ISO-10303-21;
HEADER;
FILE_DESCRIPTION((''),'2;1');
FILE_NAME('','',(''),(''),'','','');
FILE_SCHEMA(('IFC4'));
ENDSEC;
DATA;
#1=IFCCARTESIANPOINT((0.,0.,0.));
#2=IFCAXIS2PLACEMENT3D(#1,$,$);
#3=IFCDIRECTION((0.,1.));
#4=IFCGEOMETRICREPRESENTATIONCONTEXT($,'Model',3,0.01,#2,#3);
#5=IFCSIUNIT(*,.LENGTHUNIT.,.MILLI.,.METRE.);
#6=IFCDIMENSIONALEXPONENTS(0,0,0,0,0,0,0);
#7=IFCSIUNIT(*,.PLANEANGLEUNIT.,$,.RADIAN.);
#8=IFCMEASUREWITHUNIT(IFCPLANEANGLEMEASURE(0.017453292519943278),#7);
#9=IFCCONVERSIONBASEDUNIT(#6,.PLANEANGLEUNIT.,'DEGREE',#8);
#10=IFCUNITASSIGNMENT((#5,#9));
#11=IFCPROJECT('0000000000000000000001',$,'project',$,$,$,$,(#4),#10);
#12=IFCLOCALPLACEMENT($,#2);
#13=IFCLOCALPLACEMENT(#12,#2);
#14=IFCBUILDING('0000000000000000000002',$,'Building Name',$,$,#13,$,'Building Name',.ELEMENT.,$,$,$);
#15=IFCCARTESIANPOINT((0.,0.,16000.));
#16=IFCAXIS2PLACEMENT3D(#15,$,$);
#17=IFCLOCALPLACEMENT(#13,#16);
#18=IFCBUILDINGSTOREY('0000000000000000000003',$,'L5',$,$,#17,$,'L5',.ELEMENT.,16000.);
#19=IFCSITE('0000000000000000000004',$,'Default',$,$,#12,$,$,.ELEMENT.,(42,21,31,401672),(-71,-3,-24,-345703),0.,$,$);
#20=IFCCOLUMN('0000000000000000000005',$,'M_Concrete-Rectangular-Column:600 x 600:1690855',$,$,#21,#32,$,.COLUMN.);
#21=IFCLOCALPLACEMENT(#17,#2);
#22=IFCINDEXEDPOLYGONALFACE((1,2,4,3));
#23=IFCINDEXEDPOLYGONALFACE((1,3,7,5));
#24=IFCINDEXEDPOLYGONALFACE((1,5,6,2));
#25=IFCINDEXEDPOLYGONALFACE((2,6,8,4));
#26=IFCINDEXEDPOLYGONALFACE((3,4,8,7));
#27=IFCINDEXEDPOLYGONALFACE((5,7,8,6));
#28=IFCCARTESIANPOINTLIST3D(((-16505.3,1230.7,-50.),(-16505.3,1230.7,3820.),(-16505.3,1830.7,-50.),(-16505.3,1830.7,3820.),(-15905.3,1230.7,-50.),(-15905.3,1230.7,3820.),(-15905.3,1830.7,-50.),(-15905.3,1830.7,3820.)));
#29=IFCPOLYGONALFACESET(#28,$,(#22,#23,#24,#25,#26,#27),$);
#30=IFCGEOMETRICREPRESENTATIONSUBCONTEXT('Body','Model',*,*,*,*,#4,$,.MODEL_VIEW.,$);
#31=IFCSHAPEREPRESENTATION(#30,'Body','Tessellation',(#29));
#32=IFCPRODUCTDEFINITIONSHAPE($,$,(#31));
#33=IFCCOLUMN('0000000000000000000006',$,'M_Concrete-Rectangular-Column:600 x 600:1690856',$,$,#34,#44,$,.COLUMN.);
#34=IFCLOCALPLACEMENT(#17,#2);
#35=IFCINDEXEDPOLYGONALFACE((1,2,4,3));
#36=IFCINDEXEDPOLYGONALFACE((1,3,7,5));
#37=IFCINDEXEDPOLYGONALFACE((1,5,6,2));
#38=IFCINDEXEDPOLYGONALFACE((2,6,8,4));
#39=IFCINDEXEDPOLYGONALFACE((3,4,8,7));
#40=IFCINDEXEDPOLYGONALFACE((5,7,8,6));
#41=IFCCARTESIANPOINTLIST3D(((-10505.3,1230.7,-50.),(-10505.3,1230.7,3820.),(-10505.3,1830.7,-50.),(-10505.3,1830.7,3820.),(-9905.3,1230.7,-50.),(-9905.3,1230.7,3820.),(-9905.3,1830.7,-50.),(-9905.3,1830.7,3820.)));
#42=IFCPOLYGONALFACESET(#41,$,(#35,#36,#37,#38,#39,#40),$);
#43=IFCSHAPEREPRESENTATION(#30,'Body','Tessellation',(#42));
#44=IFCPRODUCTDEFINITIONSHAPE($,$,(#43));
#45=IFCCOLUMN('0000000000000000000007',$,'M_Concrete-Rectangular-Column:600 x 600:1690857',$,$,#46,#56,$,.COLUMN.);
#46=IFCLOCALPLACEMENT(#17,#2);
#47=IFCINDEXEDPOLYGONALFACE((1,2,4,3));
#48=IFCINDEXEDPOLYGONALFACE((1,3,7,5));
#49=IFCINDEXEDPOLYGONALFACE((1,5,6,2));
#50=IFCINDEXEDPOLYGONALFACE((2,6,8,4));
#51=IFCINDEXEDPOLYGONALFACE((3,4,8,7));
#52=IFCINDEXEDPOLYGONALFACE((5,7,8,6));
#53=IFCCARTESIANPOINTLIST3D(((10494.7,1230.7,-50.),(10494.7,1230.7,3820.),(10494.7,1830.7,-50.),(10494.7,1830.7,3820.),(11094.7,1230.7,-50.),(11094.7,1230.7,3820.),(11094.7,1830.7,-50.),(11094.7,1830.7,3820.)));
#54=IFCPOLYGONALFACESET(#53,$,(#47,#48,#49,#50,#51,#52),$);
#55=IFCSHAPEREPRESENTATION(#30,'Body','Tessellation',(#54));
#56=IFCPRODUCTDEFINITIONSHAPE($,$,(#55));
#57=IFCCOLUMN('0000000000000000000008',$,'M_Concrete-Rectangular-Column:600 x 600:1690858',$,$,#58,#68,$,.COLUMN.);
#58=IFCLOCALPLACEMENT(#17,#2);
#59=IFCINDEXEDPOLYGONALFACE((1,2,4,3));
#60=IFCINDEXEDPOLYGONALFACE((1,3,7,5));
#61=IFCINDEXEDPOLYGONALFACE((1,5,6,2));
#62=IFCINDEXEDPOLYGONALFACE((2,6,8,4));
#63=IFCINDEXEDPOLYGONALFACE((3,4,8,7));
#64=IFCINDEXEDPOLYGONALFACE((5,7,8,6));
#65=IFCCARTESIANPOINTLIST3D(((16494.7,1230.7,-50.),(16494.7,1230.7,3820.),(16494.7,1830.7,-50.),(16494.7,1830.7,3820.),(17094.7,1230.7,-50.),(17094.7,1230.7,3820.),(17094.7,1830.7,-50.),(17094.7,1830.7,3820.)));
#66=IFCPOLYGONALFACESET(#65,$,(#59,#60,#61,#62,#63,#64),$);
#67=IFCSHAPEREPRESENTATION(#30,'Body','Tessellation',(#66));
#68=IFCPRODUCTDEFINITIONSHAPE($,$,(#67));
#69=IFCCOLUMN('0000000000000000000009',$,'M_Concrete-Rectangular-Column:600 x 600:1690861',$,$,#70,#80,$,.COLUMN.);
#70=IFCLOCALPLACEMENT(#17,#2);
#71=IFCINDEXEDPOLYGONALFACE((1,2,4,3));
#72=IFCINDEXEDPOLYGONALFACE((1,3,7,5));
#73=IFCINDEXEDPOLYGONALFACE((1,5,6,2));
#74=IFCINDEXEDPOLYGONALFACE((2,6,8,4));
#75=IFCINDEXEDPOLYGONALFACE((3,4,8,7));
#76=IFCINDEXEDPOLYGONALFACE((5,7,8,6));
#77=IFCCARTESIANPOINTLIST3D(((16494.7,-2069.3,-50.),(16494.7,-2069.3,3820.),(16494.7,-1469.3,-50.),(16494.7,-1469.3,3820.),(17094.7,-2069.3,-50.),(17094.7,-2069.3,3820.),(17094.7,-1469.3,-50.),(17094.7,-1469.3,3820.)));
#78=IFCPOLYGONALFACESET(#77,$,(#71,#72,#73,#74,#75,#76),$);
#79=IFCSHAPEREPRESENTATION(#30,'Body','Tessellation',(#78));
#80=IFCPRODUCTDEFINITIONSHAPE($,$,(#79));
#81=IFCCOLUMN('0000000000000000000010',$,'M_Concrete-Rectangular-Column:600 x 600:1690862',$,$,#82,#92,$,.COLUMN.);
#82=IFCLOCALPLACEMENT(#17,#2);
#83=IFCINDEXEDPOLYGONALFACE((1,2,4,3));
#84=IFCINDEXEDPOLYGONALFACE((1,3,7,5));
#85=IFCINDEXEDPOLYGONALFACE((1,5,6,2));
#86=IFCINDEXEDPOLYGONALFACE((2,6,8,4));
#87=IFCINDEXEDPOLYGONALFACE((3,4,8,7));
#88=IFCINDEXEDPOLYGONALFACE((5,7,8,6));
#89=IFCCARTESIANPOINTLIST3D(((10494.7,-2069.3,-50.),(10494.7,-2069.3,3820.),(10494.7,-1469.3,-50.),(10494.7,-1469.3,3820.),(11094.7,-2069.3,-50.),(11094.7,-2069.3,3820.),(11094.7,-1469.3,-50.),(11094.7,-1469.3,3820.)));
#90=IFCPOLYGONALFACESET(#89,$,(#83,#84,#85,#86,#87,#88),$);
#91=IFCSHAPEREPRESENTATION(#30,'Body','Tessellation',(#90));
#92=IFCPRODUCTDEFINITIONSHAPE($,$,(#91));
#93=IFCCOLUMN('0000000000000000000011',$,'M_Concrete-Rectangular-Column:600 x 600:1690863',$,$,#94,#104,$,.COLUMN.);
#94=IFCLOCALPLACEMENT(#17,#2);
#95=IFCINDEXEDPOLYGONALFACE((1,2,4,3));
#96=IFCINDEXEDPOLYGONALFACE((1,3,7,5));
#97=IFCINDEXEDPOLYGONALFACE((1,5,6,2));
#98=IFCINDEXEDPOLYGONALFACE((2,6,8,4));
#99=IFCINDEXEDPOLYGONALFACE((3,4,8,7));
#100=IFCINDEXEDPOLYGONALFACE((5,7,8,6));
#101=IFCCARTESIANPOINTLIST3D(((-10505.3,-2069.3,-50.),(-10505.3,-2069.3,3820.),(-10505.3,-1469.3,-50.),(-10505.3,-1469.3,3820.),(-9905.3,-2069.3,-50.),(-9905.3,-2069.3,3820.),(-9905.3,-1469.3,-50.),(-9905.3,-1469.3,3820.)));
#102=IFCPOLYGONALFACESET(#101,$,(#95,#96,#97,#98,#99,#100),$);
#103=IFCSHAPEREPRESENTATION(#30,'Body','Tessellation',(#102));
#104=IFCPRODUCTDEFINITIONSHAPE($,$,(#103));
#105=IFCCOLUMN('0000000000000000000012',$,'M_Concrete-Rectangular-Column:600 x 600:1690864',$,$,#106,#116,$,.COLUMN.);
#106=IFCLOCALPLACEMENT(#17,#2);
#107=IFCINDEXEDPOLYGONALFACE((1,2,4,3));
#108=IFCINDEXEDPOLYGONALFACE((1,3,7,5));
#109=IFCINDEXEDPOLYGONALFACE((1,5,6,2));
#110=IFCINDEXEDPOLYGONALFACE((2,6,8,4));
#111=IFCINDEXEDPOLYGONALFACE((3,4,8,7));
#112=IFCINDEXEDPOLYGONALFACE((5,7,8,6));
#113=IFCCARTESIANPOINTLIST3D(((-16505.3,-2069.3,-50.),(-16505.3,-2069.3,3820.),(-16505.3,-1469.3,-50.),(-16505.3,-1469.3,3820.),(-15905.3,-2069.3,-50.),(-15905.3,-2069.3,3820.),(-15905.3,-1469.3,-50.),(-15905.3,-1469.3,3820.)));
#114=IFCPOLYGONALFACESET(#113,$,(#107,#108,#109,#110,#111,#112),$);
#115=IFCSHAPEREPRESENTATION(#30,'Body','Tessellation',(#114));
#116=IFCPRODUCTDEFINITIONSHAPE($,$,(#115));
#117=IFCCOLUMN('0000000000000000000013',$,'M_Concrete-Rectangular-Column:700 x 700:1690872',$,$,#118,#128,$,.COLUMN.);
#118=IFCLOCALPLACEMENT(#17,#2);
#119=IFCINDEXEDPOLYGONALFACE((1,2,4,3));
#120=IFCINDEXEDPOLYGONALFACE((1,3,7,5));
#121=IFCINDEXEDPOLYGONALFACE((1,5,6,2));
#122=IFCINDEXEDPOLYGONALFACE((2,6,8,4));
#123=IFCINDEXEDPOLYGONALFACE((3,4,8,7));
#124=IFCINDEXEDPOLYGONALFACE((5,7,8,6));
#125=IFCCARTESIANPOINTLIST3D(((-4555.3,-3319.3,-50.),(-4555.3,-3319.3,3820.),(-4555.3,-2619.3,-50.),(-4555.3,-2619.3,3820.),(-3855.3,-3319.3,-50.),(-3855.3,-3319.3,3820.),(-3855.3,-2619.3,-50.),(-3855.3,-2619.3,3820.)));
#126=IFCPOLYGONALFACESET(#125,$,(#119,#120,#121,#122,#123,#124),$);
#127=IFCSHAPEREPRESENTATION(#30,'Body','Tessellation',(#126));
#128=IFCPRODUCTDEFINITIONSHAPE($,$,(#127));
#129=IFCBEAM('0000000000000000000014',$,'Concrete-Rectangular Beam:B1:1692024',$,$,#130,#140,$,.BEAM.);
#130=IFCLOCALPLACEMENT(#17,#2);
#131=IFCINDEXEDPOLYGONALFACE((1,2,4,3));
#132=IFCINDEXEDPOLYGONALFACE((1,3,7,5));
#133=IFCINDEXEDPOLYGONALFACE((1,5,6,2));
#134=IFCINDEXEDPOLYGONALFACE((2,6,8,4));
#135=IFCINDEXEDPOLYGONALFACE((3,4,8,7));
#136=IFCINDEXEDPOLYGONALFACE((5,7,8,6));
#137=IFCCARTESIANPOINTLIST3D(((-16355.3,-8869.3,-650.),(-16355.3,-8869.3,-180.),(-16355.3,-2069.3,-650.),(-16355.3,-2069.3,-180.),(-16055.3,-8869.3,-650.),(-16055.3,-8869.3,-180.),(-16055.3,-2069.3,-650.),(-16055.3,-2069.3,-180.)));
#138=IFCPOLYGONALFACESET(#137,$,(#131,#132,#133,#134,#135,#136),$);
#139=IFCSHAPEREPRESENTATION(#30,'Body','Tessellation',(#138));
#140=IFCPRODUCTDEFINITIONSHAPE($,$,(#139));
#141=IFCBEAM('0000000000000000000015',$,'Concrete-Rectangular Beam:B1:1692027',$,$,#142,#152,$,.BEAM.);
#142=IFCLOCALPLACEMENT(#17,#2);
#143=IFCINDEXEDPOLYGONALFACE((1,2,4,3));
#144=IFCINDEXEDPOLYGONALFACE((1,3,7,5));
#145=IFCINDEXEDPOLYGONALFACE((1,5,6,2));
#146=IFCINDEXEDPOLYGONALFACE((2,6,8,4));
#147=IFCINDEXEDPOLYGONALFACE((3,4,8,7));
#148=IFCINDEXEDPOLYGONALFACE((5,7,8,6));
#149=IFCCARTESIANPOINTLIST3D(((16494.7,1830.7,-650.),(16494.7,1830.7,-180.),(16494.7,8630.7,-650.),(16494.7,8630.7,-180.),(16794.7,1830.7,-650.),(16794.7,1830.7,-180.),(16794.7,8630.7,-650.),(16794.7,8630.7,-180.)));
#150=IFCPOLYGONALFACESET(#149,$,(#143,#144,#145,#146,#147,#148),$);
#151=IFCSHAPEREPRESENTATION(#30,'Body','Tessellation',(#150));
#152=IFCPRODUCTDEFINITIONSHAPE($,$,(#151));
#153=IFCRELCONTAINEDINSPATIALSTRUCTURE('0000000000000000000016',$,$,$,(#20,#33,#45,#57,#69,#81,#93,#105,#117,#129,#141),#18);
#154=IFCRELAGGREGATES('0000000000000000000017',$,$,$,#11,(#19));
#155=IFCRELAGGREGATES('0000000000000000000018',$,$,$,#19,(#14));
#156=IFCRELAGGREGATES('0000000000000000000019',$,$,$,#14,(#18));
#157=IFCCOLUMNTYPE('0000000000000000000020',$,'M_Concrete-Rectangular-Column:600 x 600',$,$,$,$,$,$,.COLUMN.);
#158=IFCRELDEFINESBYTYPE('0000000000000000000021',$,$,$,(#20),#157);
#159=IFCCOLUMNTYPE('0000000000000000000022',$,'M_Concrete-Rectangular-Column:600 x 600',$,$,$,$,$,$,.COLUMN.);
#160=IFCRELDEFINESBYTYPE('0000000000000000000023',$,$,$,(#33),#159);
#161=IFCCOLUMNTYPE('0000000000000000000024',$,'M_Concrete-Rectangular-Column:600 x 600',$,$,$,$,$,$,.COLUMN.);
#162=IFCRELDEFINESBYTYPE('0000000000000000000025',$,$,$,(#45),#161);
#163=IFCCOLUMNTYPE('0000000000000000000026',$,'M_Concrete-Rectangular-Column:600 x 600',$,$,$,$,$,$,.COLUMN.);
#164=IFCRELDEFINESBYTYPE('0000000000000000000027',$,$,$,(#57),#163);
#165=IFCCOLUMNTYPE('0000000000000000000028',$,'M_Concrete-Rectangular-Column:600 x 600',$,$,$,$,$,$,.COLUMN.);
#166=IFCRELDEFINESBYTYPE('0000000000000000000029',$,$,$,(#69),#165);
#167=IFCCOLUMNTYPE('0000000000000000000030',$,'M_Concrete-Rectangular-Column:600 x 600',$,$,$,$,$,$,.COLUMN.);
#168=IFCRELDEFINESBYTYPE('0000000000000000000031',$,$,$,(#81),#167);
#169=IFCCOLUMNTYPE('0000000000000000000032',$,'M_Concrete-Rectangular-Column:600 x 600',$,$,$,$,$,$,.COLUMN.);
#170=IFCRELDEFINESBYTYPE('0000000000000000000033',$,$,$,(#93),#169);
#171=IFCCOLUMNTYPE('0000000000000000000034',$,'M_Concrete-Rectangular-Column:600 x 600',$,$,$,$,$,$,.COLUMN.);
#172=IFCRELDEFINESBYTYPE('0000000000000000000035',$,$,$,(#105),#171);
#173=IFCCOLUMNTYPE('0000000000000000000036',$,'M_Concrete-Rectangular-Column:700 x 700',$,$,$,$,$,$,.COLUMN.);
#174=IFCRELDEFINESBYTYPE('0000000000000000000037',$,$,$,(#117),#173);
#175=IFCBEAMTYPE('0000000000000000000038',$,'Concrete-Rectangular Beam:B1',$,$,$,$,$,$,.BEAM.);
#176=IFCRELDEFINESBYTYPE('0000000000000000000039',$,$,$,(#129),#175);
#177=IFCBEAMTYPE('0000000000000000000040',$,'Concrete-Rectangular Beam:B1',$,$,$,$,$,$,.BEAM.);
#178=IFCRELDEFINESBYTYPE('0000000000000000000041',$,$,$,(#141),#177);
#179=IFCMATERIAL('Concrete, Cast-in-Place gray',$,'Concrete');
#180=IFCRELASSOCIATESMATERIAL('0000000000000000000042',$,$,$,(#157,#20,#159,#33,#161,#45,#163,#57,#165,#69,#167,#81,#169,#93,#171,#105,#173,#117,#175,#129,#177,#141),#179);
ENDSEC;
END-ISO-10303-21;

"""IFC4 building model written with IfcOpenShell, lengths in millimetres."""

from ifc_helpers import new_model, entity, si_unit, converted_unit, direction, frame, origin, place, context, subcontext, project, spatial, indexed_curve, outline, extrude, source, transform, mapped, material, type_object, type_shapes, element, save


model = new_model("IFC4")

# Units and contexts
model_context = context("Model", 3, precision=0.01, world=origin(), true_north=direction((0.0, 1.0)))
body_context = subcontext(model_context, "Body", "Model", "MODEL_VIEW")
ifc_project = project(units=[si_unit("LENGTHUNIT", "METRE", prefix="MILLI"), converted_unit("PLANEANGLEUNIT", "DEGREE", entity("IfcPlaneAngleMeasure", 0.017453292519943278), si_unit("PLANEANGLEUNIT", "RADIAN"), dimensions=[0, 0, 0, 0, 0, 0, 0])], contexts=[model_context])

# Site, building, storey
site_placement = place(None, origin())
site = spatial("IfcSite", under=ifc_project, at=site_placement, Name="Default", CompositionType="ELEMENT", RefLatitude=(42, 21, 31, 401672), RefLongitude=(-71, -3, -24, -345703), RefElevation=0.0)
building_placement = place(site_placement, origin())
building = spatial("IfcBuilding", under=site, at=building_placement, Name="Building Name", LongName="Building Name", CompositionType="ELEMENT")
storey_placement = place(building_placement, frame((0.0, 0.0, 16000.0)))
storey = spatial("IfcBuildingStorey", under=building, at=storey_placement, Name="L5", LongName="L5", CompositionType="ELEMENT", Elevation=16000.0)

# Columns
ifc_material = material(Name="Concrete, Cast-in-Place gray", Category="Concrete")
column_type_1 = type_object("IfcColumnType", Name="M_Concrete-Rectangular-Column:600 x 600", PredefinedType="COLUMN", material=ifc_material)
shared_shape_1 = source(origin(), body_context, "Body", "SweptSolid", [
    extrude(outline(indexed_curve([(-300.0, -300.0), (300.0, -300.0), (300.0, 300.0), (-300.0, 300.0), (-300.0, -300.0)], self_intersect=False)), frame((-16205.3, 1530.7, 15950.0), z_axis=(0.0, 0.0, 1.0), x_axis=(-1.0, 0.0, 0.0)), (0.0, 0.0, 1.0), 3870.0),
])
type_shapes(column_type_1, [shared_shape_1])
column_1_placement = place(storey_placement, frame((0.0, 0.0, -16000.0)))
element("IfcColumn", 1, at=column_1_placement, inside=storey, type_object=column_type_1, material=ifc_material, Name="M_Concrete-Rectangular-Column:600 x 600:1690855", PredefinedType="COLUMN", context=body_context, shape_type="MappedRepresentation", body=[
    mapped(shared_shape_1, transform((0.0, 0.0, 0.0), scale=1.0)),
])
column_type_2 = type_object("IfcColumnType", Name="M_Concrete-Rectangular-Column:600 x 600", PredefinedType="COLUMN", material=ifc_material)
shared_shape_2 = source(origin(), body_context, "Body", "SweptSolid", [
    extrude(outline(indexed_curve([(-300.0, -300.0), (300.0, -300.0), (300.0, 300.0), (-300.0, 300.0), (-300.0, -300.0)], self_intersect=False)), frame((-10205.3, 1530.7, 15950.0), z_axis=(0.0, 0.0, 1.0), x_axis=(-1.0, 0.0, 0.0)), (0.0, 0.0, 1.0), 3870.0),
])
type_shapes(column_type_2, [shared_shape_2])
column_2_placement = place(storey_placement, frame((0.0, 0.0, -16000.0)))
element("IfcColumn", 2, at=column_2_placement, inside=storey, type_object=column_type_2, material=ifc_material, Name="M_Concrete-Rectangular-Column:600 x 600:1690856", PredefinedType="COLUMN", context=body_context, shape_type="MappedRepresentation", body=[
    mapped(shared_shape_2, transform((0.0, 0.0, 0.0), scale=1.0)),
])
column_type_3 = type_object("IfcColumnType", Name="M_Concrete-Rectangular-Column:600 x 600", PredefinedType="COLUMN", material=ifc_material)
shared_shape_3 = source(origin(), body_context, "Body", "SweptSolid", [
    extrude(outline(indexed_curve([(-300.0, -300.0), (300.0, -300.0), (300.0, 300.0), (-300.0, 300.0), (-300.0, -300.0)], self_intersect=False)), frame((10794.7, 1530.7, 15950.0), z_axis=(0.0, 0.0, 1.0), x_axis=(-1.0, 0.0, 0.0)), (0.0, 0.0, 1.0), 3870.0),
])
type_shapes(column_type_3, [shared_shape_3])
column_3_placement = place(storey_placement, frame((0.0, 0.0, -16000.0)))
element("IfcColumn", 3, at=column_3_placement, inside=storey, type_object=column_type_3, material=ifc_material, Name="M_Concrete-Rectangular-Column:600 x 600:1690857", PredefinedType="COLUMN", context=body_context, shape_type="MappedRepresentation", body=[
    mapped(shared_shape_3, transform((0.0, 0.0, 0.0), scale=1.0)),
])
column_type_4 = type_object("IfcColumnType", Name="M_Concrete-Rectangular-Column:600 x 600", PredefinedType="COLUMN", material=ifc_material)
shared_shape_4 = source(origin(), body_context, "Body", "SweptSolid", [
    extrude(outline(indexed_curve([(-300.0, -300.0), (300.0, -300.0), (300.0, 300.0), (-300.0, 300.0), (-300.0, -300.0)], self_intersect=False)), frame((16794.7, 1530.7, 15950.0), z_axis=(0.0, 0.0, 1.0), x_axis=(-1.0, 0.0, 0.0)), (0.0, 0.0, 1.0), 3870.0),
])
type_shapes(column_type_4, [shared_shape_4])
column_4_placement = place(storey_placement, frame((0.0, 0.0, -16000.0)))
element("IfcColumn", 4, at=column_4_placement, inside=storey, type_object=column_type_4, material=ifc_material, Name="M_Concrete-Rectangular-Column:600 x 600:1690858", PredefinedType="COLUMN", context=body_context, shape_type="MappedRepresentation", body=[
    mapped(shared_shape_4, transform((0.0, 0.0, 0.0), scale=1.0)),
])
column_type_5 = type_object("IfcColumnType", Name="M_Concrete-Rectangular-Column:600 x 600", PredefinedType="COLUMN", material=ifc_material)
shared_shape_5 = source(origin(), body_context, "Body", "SweptSolid", [
    extrude(outline(indexed_curve([(-300.0, -300.0), (300.0, -300.0), (300.0, 300.0), (-300.0, 300.0), (-300.0, -300.0)], self_intersect=False)), frame((16794.7, -1769.3, 15950.0), z_axis=(0.0, 0.0, 1.0), x_axis=(-1.0, 0.0, 0.0)), (0.0, 0.0, 1.0), 3870.0),
])
type_shapes(column_type_5, [shared_shape_5])
column_5_placement = place(storey_placement, frame((0.0, 0.0, -16000.0)))
element("IfcColumn", 5, at=column_5_placement, inside=storey, type_object=column_type_5, material=ifc_material, Name="M_Concrete-Rectangular-Column:600 x 600:1690861", PredefinedType="COLUMN", context=body_context, shape_type="MappedRepresentation", body=[
    mapped(shared_shape_5, transform((0.0, 0.0, 0.0), scale=1.0)),
])
column_type_6 = type_object("IfcColumnType", Name="M_Concrete-Rectangular-Column:600 x 600", PredefinedType="COLUMN", material=ifc_material)
shared_shape_6 = source(origin(), body_context, "Body", "SweptSolid", [
    extrude(outline(indexed_curve([(-300.0, -300.0), (300.0, -300.0), (300.0, 300.0), (-300.0, 300.0), (-300.0, -300.0)], self_intersect=False)), frame((10794.7, -1769.3, 15950.0), z_axis=(0.0, 0.0, 1.0), x_axis=(-1.0, 0.0, 0.0)), (0.0, 0.0, 1.0), 3870.0),
])
type_shapes(column_type_6, [shared_shape_6])
column_6_placement = place(storey_placement, frame((0.0, 0.0, -16000.0)))
element("IfcColumn", 6, at=column_6_placement, inside=storey, type_object=column_type_6, material=ifc_material, Name="M_Concrete-Rectangular-Column:600 x 600:1690862", PredefinedType="COLUMN", context=body_context, shape_type="MappedRepresentation", body=[
    mapped(shared_shape_6, transform((0.0, 0.0, 0.0), scale=1.0)),
])
column_type_7 = type_object("IfcColumnType", Name="M_Concrete-Rectangular-Column:600 x 600", PredefinedType="COLUMN", material=ifc_material)
shared_shape_7 = source(origin(), body_context, "Body", "SweptSolid", [
    extrude(outline(indexed_curve([(-300.0, -300.0), (300.0, -300.0), (300.0, 300.0), (-300.0, 300.0), (-300.0, -300.0)], self_intersect=False)), frame((-10205.3, -1769.3, 15950.0), z_axis=(0.0, 0.0, 1.0), x_axis=(-1.0, 0.0, 0.0)), (0.0, 0.0, 1.0), 3870.0),
])
type_shapes(column_type_7, [shared_shape_7])
column_7_placement = place(storey_placement, frame((0.0, 0.0, -16000.0)))
element("IfcColumn", 7, at=column_7_placement, inside=storey, type_object=column_type_7, material=ifc_material, Name="M_Concrete-Rectangular-Column:600 x 600:1690863", PredefinedType="COLUMN", context=body_context, shape_type="MappedRepresentation", body=[
    mapped(shared_shape_7, transform((0.0, 0.0, 0.0), scale=1.0)),
])
column_type_8 = type_object("IfcColumnType", Name="M_Concrete-Rectangular-Column:600 x 600", PredefinedType="COLUMN", material=ifc_material)
shared_shape_8 = source(origin(), body_context, "Body", "SweptSolid", [
    extrude(outline(indexed_curve([(-300.0, -300.0), (300.0, -300.0), (300.0, 300.0), (-300.0, 300.0), (-300.0, -300.0)], self_intersect=False)), frame((-16205.3, -1769.3, 15950.0), z_axis=(0.0, 0.0, 1.0), x_axis=(-1.0, 0.0, 0.0)), (0.0, 0.0, 1.0), 3870.0),
])
type_shapes(column_type_8, [shared_shape_8])
column_8_placement = place(storey_placement, frame((0.0, 0.0, -16000.0)))
element("IfcColumn", 8, at=column_8_placement, inside=storey, type_object=column_type_8, material=ifc_material, Name="M_Concrete-Rectangular-Column:600 x 600:1690864", PredefinedType="COLUMN", context=body_context, shape_type="MappedRepresentation", body=[
    mapped(shared_shape_8, transform((0.0, 0.0, 0.0), scale=1.0)),
])
column_type_9 = type_object("IfcColumnType", Name="M_Concrete-Rectangular-Column:700 x 700", PredefinedType="COLUMN", material=ifc_material)
shared_shape_9 = source(origin(), body_context, "Body", "SweptSolid", [
    extrude(outline(indexed_curve([(-350.0, -350.0), (350.0, -350.0), (350.0, 350.0), (-350.0, 350.0), (-350.0, -350.0)], self_intersect=False)), frame((-4205.3, -2969.3, 15950.0), z_axis=(0.0, 0.0, 1.0), x_axis=(-1.0, 0.0, 0.0)), (0.0, 0.0, 1.0), 3870.0),
])
type_shapes(column_type_9, [shared_shape_9])
column_9_placement = place(storey_placement, frame((0.0, 0.0, -16000.0)))
element("IfcColumn", 9, at=column_9_placement, inside=storey, type_object=column_type_9, material=ifc_material, Name="M_Concrete-Rectangular-Column:700 x 700:1690872", PredefinedType="COLUMN", context=body_context, shape_type="MappedRepresentation", body=[
    mapped(shared_shape_9, transform((0.0, 0.0, 0.0), scale=1.0)),
])

# Beams
beam_type_1 = type_object("IfcBeamType", Name="Concrete-Rectangular Beam:B1", PredefinedType="BEAM", material=ifc_material)
shared_shape_10 = source(origin(), body_context, "Body", "SweptSolid", [
    extrude(outline(indexed_curve([(-150.0, -235.0), (150.0, -235.0), (150.0, 235.0), (-150.0, 235.0), (-150.0, -235.0)], self_intersect=False)), frame((-16205.3, -2069.3, 15585.0), z_axis=(0.0, -1.0, 0.0), x_axis=(-1.0, 0.0, 0.0)), (0.0, 0.0, 1.0), 6800.0),
])
type_shapes(beam_type_1, [shared_shape_10])
beam_1_placement = place(storey_placement, frame((0.0, 0.0, -16000.0)))
element("IfcBeam", 10, at=beam_1_placement, inside=storey, type_object=beam_type_1, material=ifc_material, Name="Concrete-Rectangular Beam:B1:1692024", PredefinedType="BEAM", context=body_context, shape_type="MappedRepresentation", body=[
    mapped(shared_shape_10, transform((0.0, 0.0, 0.0), scale=1.0)),
])
beam_type_2 = type_object("IfcBeamType", Name="Concrete-Rectangular Beam:B1", PredefinedType="BEAM", material=ifc_material)
shared_shape_11 = source(origin(), body_context, "Body", "SweptSolid", [
    extrude(outline(indexed_curve([(-150.0, -235.0), (150.0, -235.0), (150.0, 235.0), (-150.0, 235.0), (-150.0, -235.0)], self_intersect=False)), frame((16644.7, 8630.7, 15585.0), z_axis=(0.0, -1.0, 0.0), x_axis=(-1.0, 0.0, 0.0)), (0.0, 0.0, 1.0), 6800.0),
])
type_shapes(beam_type_2, [shared_shape_11])
beam_2_placement = place(storey_placement, frame((0.0, 0.0, -16000.0)))
element("IfcBeam", 11, at=beam_2_placement, inside=storey, type_object=beam_type_2, material=ifc_material, Name="Concrete-Rectangular Beam:B1:1692027", PredefinedType="BEAM", context=body_context, shape_type="MappedRepresentation", body=[
    mapped(shared_shape_11, transform((0.0, 0.0, 0.0), scale=1.0)),
])

save(model, "model.ifc")
